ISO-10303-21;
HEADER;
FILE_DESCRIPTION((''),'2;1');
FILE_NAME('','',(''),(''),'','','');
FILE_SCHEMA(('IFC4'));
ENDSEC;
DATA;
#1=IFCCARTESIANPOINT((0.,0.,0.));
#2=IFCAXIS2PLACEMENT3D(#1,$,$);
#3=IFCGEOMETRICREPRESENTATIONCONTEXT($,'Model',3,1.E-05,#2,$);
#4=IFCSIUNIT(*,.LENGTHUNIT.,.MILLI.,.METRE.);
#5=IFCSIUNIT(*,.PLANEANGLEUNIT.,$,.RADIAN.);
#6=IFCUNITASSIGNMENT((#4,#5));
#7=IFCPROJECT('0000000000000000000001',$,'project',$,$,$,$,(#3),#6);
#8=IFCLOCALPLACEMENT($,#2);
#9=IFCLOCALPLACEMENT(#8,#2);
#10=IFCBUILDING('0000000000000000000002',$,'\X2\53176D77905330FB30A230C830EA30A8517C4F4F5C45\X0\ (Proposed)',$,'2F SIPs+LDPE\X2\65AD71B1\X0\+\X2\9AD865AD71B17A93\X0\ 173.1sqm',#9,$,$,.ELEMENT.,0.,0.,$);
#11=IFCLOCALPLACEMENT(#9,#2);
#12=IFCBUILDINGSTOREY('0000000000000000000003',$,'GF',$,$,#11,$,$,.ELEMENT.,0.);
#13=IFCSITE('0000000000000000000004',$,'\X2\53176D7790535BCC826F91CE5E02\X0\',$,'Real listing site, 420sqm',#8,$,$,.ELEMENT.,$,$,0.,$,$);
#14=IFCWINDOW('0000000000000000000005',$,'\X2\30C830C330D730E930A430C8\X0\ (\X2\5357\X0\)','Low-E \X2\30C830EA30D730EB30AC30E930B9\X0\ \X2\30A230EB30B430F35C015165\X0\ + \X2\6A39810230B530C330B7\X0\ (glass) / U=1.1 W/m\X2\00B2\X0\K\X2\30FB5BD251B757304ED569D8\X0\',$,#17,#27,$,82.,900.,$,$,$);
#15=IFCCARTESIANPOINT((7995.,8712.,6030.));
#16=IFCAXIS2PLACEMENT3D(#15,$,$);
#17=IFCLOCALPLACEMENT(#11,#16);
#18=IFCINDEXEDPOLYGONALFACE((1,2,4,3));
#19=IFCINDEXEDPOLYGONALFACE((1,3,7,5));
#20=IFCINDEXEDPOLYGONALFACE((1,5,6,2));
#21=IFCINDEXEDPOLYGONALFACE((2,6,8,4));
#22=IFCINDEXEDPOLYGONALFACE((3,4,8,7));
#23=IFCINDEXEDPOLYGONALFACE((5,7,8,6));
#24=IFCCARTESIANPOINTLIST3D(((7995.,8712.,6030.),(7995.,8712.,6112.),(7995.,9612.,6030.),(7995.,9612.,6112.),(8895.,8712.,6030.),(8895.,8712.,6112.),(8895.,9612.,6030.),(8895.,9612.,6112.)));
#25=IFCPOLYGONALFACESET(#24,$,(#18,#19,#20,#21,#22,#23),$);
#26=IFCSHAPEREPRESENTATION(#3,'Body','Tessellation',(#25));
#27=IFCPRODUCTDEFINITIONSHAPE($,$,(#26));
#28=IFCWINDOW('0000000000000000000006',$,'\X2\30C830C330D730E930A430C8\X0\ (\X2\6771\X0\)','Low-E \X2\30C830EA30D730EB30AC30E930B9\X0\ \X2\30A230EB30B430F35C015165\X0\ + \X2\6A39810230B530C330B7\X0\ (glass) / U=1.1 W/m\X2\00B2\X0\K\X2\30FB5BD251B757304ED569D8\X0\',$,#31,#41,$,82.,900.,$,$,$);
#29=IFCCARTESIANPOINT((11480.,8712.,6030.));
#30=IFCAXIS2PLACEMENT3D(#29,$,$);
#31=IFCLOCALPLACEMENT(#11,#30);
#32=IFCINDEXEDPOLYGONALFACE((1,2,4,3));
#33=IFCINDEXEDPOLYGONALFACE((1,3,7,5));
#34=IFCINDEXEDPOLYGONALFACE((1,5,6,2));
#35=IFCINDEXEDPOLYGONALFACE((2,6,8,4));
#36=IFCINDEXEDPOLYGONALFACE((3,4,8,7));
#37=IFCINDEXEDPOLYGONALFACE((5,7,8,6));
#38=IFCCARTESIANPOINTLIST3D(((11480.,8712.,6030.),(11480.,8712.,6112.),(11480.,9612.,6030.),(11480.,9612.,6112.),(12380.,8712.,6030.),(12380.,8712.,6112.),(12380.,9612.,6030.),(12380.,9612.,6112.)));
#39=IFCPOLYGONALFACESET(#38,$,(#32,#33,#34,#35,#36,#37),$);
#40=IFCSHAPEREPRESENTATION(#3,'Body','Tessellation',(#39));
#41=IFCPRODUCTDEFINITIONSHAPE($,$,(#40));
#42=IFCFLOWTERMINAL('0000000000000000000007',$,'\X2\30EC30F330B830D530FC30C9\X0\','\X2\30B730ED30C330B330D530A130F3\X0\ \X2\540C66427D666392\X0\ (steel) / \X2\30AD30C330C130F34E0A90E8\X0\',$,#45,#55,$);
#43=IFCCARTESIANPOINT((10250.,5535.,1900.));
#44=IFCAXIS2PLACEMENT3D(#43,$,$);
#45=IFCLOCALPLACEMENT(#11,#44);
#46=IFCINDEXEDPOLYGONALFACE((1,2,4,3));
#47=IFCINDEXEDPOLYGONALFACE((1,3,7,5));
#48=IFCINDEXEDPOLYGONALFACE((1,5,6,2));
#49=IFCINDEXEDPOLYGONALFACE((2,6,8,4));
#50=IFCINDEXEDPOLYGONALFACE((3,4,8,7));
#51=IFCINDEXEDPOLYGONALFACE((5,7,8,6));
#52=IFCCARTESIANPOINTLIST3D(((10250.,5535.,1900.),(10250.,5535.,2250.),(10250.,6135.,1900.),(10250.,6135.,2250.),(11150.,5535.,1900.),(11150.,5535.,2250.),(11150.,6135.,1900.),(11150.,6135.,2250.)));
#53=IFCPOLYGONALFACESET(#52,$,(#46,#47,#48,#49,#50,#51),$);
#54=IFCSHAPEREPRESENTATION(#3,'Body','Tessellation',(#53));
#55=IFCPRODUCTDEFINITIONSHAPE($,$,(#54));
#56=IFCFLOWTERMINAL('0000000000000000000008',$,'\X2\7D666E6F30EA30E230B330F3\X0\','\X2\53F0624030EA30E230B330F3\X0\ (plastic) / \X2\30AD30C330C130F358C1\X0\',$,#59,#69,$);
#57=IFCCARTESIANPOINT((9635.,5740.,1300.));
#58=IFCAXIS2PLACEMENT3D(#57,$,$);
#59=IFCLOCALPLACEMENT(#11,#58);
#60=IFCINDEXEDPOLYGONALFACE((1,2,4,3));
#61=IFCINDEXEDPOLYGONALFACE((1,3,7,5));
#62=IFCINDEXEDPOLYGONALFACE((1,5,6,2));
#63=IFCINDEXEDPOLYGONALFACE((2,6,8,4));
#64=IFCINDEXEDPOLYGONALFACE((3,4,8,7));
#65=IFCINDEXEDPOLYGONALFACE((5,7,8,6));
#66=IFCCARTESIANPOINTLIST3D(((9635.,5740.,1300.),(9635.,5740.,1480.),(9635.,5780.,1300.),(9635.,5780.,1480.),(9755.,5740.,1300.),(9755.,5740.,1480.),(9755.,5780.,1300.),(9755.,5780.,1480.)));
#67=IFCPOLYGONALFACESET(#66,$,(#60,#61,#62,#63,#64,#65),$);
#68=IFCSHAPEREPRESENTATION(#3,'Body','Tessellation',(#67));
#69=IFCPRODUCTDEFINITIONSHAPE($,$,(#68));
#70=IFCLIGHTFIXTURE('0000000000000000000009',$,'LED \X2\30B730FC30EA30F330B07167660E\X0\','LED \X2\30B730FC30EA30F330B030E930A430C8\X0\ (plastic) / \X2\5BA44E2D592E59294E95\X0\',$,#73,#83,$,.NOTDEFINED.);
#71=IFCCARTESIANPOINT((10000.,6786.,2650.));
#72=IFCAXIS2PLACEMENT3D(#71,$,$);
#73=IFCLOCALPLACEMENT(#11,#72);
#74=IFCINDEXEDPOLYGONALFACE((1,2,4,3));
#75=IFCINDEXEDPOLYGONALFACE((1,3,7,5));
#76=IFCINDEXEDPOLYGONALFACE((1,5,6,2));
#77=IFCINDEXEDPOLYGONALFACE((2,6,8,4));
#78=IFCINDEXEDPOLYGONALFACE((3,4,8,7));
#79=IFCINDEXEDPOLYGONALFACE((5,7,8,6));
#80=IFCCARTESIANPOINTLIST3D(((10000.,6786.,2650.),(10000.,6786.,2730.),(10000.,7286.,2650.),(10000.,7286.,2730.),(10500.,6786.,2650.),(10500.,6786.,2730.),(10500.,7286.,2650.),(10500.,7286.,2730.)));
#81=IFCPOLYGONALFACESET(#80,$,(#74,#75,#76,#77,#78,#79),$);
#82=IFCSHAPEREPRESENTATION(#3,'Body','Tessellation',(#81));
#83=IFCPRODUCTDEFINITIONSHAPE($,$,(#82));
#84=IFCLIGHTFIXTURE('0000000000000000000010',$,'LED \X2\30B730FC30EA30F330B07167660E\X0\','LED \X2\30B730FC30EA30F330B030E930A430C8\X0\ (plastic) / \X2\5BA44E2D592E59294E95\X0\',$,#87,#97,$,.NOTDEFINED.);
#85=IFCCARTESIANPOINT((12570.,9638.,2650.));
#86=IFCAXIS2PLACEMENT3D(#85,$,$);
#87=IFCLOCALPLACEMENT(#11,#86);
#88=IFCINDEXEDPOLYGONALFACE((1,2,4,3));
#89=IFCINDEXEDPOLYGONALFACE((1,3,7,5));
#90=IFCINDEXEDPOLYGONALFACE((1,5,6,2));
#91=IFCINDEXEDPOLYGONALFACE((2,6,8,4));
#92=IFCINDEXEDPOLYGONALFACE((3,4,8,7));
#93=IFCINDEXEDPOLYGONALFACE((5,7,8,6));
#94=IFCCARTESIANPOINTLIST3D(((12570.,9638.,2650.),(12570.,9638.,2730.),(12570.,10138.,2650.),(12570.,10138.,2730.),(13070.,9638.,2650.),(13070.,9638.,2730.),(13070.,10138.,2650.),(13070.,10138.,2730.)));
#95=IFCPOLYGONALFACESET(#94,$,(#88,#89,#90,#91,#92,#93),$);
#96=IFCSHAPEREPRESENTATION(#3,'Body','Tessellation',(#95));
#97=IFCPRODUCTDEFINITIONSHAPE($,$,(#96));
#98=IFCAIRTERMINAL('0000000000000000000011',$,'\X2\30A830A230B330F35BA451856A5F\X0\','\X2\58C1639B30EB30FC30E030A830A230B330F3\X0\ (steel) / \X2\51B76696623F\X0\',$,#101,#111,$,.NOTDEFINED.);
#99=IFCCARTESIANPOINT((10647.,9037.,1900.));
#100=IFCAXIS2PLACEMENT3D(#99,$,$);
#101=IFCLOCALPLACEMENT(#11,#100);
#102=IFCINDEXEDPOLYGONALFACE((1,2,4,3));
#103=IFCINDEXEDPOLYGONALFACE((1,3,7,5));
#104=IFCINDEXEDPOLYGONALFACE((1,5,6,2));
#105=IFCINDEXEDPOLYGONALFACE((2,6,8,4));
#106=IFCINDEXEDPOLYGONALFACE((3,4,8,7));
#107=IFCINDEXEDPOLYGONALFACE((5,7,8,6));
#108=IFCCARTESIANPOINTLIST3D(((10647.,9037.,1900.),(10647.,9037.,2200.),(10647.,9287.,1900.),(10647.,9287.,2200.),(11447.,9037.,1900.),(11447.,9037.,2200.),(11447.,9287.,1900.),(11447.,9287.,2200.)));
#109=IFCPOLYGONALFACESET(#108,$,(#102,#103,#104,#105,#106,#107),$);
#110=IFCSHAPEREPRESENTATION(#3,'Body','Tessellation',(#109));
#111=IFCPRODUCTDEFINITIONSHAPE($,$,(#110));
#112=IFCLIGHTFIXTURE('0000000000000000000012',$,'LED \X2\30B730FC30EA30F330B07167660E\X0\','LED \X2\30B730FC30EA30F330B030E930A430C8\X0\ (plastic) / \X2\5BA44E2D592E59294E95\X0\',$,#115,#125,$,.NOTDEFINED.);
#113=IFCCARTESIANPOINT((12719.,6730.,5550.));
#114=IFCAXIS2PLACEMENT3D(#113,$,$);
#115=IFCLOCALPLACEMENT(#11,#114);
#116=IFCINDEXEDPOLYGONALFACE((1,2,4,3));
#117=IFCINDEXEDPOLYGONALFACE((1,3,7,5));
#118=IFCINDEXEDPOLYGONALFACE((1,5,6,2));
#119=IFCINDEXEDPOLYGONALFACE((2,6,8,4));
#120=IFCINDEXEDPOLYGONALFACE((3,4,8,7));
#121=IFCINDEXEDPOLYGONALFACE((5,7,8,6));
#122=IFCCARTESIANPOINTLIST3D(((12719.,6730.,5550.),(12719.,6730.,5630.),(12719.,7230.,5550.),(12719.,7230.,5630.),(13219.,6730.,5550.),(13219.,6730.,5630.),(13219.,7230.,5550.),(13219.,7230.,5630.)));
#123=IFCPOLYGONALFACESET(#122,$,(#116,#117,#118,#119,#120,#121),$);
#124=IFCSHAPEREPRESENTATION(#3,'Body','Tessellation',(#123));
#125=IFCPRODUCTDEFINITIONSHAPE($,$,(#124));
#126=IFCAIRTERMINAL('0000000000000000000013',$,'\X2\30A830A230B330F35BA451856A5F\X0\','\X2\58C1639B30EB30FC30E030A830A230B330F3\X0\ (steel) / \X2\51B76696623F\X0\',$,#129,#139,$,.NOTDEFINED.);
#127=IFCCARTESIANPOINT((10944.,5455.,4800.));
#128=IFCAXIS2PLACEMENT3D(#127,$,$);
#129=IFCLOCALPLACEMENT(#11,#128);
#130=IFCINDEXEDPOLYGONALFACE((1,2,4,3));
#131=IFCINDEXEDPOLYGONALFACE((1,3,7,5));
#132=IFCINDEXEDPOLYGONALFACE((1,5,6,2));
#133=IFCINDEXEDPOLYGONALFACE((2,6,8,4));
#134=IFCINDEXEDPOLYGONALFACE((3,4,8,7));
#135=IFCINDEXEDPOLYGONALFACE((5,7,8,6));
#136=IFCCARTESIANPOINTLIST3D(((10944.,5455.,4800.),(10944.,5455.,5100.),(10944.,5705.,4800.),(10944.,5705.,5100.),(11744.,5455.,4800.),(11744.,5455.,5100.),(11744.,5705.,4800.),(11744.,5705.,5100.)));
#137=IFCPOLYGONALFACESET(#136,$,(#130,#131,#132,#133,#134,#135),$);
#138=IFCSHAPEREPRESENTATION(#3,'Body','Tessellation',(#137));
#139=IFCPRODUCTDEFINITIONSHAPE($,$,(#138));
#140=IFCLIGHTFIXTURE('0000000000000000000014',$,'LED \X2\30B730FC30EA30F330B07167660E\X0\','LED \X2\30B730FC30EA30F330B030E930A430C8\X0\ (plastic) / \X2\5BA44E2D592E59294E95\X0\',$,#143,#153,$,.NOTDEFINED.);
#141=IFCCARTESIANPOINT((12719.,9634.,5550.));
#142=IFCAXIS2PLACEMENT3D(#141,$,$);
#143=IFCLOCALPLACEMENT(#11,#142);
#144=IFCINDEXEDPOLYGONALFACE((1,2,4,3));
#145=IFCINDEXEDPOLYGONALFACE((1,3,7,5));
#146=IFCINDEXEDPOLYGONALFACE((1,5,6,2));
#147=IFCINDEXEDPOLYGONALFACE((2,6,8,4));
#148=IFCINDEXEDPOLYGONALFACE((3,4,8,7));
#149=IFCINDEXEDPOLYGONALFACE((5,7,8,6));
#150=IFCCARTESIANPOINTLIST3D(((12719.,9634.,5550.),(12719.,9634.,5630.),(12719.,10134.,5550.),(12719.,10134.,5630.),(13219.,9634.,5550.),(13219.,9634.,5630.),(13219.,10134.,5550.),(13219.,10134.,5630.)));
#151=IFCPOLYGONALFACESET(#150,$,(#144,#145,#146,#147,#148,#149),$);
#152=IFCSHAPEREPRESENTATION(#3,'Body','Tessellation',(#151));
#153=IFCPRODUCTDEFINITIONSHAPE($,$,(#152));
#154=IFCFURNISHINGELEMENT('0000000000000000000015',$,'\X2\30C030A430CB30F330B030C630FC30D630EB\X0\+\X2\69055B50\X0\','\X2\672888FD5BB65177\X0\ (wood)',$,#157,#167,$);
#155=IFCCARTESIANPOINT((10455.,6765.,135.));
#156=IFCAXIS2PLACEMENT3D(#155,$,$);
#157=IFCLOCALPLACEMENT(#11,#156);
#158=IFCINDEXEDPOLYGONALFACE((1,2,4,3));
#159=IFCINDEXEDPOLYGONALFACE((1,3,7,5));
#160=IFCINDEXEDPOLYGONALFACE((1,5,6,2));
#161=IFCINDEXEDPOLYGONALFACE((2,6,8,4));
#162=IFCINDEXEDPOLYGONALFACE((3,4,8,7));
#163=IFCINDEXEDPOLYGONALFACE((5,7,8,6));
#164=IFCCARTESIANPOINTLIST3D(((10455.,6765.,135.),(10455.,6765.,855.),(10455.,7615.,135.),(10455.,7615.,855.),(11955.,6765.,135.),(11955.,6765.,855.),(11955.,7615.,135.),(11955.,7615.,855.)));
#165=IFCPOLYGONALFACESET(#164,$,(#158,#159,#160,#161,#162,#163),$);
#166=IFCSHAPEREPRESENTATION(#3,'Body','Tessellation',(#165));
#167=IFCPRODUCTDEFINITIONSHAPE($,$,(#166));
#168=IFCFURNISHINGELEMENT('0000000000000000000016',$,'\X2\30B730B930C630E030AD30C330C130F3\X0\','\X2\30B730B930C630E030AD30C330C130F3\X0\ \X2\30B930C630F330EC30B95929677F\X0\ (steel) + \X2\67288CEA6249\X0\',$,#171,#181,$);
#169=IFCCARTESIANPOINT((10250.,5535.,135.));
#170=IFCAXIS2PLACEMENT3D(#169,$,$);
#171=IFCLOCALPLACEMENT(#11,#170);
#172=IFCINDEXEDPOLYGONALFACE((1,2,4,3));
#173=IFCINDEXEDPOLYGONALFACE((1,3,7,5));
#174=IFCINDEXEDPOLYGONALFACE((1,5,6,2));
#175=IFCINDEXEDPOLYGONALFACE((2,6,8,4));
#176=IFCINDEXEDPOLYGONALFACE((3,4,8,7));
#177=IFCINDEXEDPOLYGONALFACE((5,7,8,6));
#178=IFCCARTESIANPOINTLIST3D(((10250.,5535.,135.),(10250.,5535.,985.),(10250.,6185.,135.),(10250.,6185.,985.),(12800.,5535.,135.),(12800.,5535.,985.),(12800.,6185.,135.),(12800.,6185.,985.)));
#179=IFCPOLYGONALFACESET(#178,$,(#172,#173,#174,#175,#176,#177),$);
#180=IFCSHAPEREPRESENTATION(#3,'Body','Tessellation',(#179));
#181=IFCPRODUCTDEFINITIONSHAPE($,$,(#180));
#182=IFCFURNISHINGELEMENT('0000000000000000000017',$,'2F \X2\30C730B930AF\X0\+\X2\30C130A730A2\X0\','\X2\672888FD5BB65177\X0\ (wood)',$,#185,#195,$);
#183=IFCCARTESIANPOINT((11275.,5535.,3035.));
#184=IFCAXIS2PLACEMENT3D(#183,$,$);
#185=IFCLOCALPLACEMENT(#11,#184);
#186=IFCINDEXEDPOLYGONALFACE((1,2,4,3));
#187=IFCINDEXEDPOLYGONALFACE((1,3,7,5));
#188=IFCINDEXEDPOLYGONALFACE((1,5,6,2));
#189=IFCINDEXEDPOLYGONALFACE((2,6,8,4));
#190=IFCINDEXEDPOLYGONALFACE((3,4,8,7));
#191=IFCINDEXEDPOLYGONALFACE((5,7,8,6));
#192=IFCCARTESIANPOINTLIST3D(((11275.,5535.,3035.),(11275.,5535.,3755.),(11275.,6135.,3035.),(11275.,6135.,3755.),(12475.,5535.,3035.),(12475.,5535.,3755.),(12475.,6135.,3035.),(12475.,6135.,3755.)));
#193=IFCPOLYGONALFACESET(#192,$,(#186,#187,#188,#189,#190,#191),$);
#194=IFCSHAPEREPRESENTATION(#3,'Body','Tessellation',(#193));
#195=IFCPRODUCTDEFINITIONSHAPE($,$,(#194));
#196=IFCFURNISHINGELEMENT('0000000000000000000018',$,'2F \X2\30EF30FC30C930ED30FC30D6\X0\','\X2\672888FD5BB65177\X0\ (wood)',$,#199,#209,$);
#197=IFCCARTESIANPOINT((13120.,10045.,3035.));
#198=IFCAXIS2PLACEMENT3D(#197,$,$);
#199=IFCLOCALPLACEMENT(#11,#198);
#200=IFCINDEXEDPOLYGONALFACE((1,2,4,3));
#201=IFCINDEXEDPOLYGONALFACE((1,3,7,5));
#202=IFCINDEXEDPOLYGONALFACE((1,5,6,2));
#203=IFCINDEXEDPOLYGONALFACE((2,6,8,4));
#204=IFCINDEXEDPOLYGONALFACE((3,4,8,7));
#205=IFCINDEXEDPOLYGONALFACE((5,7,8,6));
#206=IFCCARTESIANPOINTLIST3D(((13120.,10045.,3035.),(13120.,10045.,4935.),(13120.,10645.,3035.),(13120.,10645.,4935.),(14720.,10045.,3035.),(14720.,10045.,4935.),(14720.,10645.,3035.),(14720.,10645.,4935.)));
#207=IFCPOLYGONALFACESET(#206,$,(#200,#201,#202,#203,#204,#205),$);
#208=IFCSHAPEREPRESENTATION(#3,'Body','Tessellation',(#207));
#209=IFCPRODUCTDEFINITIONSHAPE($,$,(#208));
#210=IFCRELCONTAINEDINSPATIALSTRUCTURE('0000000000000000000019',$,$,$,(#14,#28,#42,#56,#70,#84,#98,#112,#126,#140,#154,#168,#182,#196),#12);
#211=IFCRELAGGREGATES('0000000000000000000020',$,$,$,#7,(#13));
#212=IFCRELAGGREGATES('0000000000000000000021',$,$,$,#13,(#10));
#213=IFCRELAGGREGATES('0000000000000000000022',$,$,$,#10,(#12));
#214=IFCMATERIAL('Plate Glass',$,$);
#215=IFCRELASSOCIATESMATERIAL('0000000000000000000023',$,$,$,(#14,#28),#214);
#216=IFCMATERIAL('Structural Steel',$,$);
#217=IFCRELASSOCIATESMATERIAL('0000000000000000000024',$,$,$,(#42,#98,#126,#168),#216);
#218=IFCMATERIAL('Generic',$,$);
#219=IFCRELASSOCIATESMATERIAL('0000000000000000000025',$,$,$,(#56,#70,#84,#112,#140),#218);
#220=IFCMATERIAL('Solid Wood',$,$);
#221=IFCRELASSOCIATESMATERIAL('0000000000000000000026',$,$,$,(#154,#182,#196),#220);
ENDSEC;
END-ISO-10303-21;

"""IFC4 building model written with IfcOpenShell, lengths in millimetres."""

from ifc_helpers import new_model, si_unit, frame, frame_2d, origin, place, context, project, spatial, rectangle, extrude, material, element, save


model = new_model("IFC4")

# Units and contexts
model_context = context("Model", 3, precision=1e-05, world=origin())
ifc_project = project(units=[si_unit("LENGTHUNIT", "METRE", prefix="MILLI"), si_unit("PLANEANGLEUNIT", "RADIAN")], contexts=[model_context])

# Site, building, storey
site_placement = place(None, origin())
site = spatial("IfcSite", under=ifc_project, at=site_placement, Name="北海道富良野市", ObjectType="Real listing site, 420sqm", CompositionType="ELEMENT", RefElevation=0.0)
building_placement = place(site_placement, origin())
building = spatial("IfcBuilding", under=site, at=building_placement, Name="北海道・アトリエ兼住居 (Proposed)", ObjectType="2F SIPs+LDPE断熱+高断熱窓 173.1sqm", CompositionType="ELEMENT", ElevationOfRefHeight=0.0, ElevationOfTerrain=0.0)
storey_placement = place(building_placement, origin())
storey = spatial("IfcBuildingStorey", under=building, at=storey_placement, Name="GF", CompositionType="ELEMENT", Elevation=0.0)

# Shared definitions
ifc_material_1 = material(Name="Solid Wood")

# Windows
ifc_material_2 = material(Name="Plate Glass")
window_1_placement = place(storey_placement, frame((7995.0, 8712.0, 6030.0)))
element("IfcWindow", 1, at=window_1_placement, inside=storey, material=ifc_material_2, Name="トップライト (南)", Description="Low-E トリプルガラス アルゴン封入 + 樹脂サッシ (glass) / U=1.1 W/m²K・寒冷地仕様", OverallHeight=82.0, OverallWidth=900.0, context=model_context, shape_type="SweptSolid", body=[
    extrude(rectangle(XDim=900.0, YDim=900.0, at=frame_2d((450.0, 450.0))), frame((7995.0, 8712.0, 6030.0)), (0.0, 0.0, 1.0), 82.0),
])
window_2_placement = place(storey_placement, frame((11480.0, 8712.0, 6030.0)))
element("IfcWindow", 2, at=window_2_placement, inside=storey, material=ifc_material_2, Name="トップライト (東)", Description="Low-E トリプルガラス アルゴン封入 + 樹脂サッシ (glass) / U=1.1 W/m²K・寒冷地仕様", OverallHeight=82.0, OverallWidth=900.0, context=model_context, shape_type="SweptSolid", body=[
    extrude(rectangle(XDim=900.0, YDim=900.0, at=frame_2d((450.0, 450.0))), frame((11480.0, 8712.0, 6030.0)), (0.0, 0.0, 1.0), 82.0),
])

# Flow terminals
ifc_material_3 = material(Name="Structural Steel")
flow_terminal_1_placement = place(storey_placement, frame((10250.0, 5535.0, 1900.0)))
element("IfcFlowTerminal", 3, at=flow_terminal_1_placement, inside=storey, material=ifc_material_3, Name="レンジフード", Description="シロッコファン 同時給排 (steel) / キッチン上部", context=model_context, shape_type="SweptSolid", body=[
    extrude(rectangle(XDim=900.0, YDim=600.0, at=frame_2d((450.0, 300.0))), frame((10250.0, 5535.0, 1900.0)), (0.0, 0.0, 1.0), 350.0),
])
ifc_material_4 = material(Name="Generic")
flow_terminal_2_placement = place(storey_placement, frame((9635.0, 5740.0, 1300.0)))
element("IfcFlowTerminal", 4, at=flow_terminal_2_placement, inside=storey, material=ifc_material_4, Name="給湯リモコン", Description="台所リモコン (plastic) / キッチン壁", context=model_context, shape_type="SweptSolid", body=[
    extrude(rectangle(XDim=120.0, YDim=40.0, at=frame_2d((60.0, 20.0))), frame((9635.0, 5740.0, 1300.0)), (0.0, 0.0, 1.0), 180.0),
])

# Light fixtures
light_fixture_1_placement = place(storey_placement, frame((10000.0, 6786.0, 2650.0)))
element("IfcLightFixture", 5, at=light_fixture_1_placement, inside=storey, material=ifc_material_4, Name="LED シーリング照明", Description="LED シーリングライト (plastic) / 室中央天井", PredefinedType="NOTDEFINED", context=model_context, shape_type="SweptSolid", body=[
    extrude(rectangle(XDim=500.0, YDim=500.0, at=frame_2d((250.0, 250.0))), frame((10000.0, 6786.0, 2650.0)), (0.0, 0.0, 1.0), 80.0),
])
light_fixture_2_placement = place(storey_placement, frame((12570.0, 9638.0, 2650.0)))
element("IfcLightFixture", 6, at=light_fixture_2_placement, inside=storey, material=ifc_material_4, Name="LED シーリング照明", Description="LED シーリングライト (plastic) / 室中央天井", PredefinedType="NOTDEFINED", context=model_context, shape_type="SweptSolid", body=[
    extrude(rectangle(XDim=500.0, YDim=500.0, at=frame_2d((250.0, 250.0))), frame((12570.0, 9638.0, 2650.0)), (0.0, 0.0, 1.0), 80.0),
])

# Air terminal
air_terminal_1_placement = place(storey_placement, frame((10647.0, 9037.0, 1900.0)))
element("IfcAirTerminal", 7, at=air_terminal_1_placement, inside=storey, material=ifc_material_3, Name="エアコン室内機", Description="壁掛ルームエアコン (steel) / 冷暖房", PredefinedType="NOTDEFINED", context=model_context, shape_type="SweptSolid", body=[
    extrude(rectangle(XDim=800.0, YDim=250.0, at=frame_2d((400.0, 125.0))), frame((10647.0, 9037.0, 1900.0)), (0.0, 0.0, 1.0), 300.0),
])

# Light fixture
light_fixture_3_placement = place(storey_placement, frame((12719.0, 6730.0, 5550.0)))
element("IfcLightFixture", 8, at=light_fixture_3_placement, inside=storey, material=ifc_material_4, Name="LED シーリング照明", Description="LED シーリングライト (plastic) / 室中央天井", PredefinedType="NOTDEFINED", context=model_context, shape_type="SweptSolid", body=[
    extrude(rectangle(XDim=500.0, YDim=500.0, at=frame_2d((250.0, 250.0))), frame((12719.0, 6730.0, 5550.0)), (0.0, 0.0, 1.0), 80.0),
])

# Air terminal
air_terminal_2_placement = place(storey_placement, frame((10944.0, 5455.0, 4800.0)))
element("IfcAirTerminal", 9, at=air_terminal_2_placement, inside=storey, material=ifc_material_3, Name="エアコン室内機", Description="壁掛ルームエアコン (steel) / 冷暖房", PredefinedType="NOTDEFINED", context=model_context, shape_type="SweptSolid", body=[
    extrude(rectangle(XDim=800.0, YDim=250.0, at=frame_2d((400.0, 125.0))), frame((10944.0, 5455.0, 4800.0)), (0.0, 0.0, 1.0), 300.0),
])

# Light fixture
light_fixture_4_placement = place(storey_placement, frame((12719.0, 9634.0, 5550.0)))
element("IfcLightFixture", 10, at=light_fixture_4_placement, inside=storey, material=ifc_material_4, Name="LED シーリング照明", Description="LED シーリングライト (plastic) / 室中央天井", PredefinedType="NOTDEFINED", context=model_context, shape_type="SweptSolid", body=[
    extrude(rectangle(XDim=500.0, YDim=500.0, at=frame_2d((250.0, 250.0))), frame((12719.0, 9634.0, 5550.0)), (0.0, 0.0, 1.0), 80.0),
])

# Furnishing elements
furnishing_1_placement = place(storey_placement, frame((10455.0, 6765.0, 135.0)))
element("IfcFurnishingElement", 11, at=furnishing_1_placement, inside=storey, material=ifc_material_1, Name="ダイニングテーブル+椅子", Description="木製家具 (wood)", context=model_context, shape_type="SweptSolid", body=[
    extrude(rectangle(XDim=1500.0, YDim=850.0, at=frame_2d((750.0, 425.0))), frame((10455.0, 6765.0, 135.0)), (0.0, 0.0, 1.0), 720.0),
])
furnishing_2_placement = place(storey_placement, frame((10250.0, 5535.0, 135.0)))
element("IfcFurnishingElement", 12, at=furnishing_2_placement, inside=storey, material=ifc_material_3, Name="システムキッチン", Description="システムキッチン ステンレス天板 (steel) + 木質扉", context=model_context, shape_type="SweptSolid", body=[
    extrude(rectangle(XDim=2550.0, YDim=650.0, at=frame_2d((1275.0, 325.0))), frame((10250.0, 5535.0, 135.0)), (0.0, 0.0, 1.0), 850.0),
])
furnishing_3_placement = place(storey_placement, frame((11275.0, 5535.0, 3035.0)))
element("IfcFurnishingElement", 13, at=furnishing_3_placement, inside=storey, material=ifc_material_1, Name="2F デスク+チェア", Description="木製家具 (wood)", context=model_context, shape_type="SweptSolid", body=[
    extrude(rectangle(XDim=1200.0, YDim=600.0, at=frame_2d((600.0, 300.0))), frame((11275.0, 5535.0, 3035.0)), (0.0, 0.0, 1.0), 720.0),
])
furnishing_4_placement = place(storey_placement, frame((13120.0, 10045.0, 3035.0)))
element("IfcFurnishingElement", 14, at=furnishing_4_placement, inside=storey, material=ifc_material_1, Name="2F ワードローブ", Description="木製家具 (wood)", context=model_context, shape_type="SweptSolid", body=[
    extrude(rectangle(XDim=1600.0, YDim=600.0, at=frame_2d((800.0, 300.0))), frame((13120.0, 10045.0, 3035.0)), (0.0, 0.0, 1.0), 1900.0),
])

save(model, "model.ifc")
